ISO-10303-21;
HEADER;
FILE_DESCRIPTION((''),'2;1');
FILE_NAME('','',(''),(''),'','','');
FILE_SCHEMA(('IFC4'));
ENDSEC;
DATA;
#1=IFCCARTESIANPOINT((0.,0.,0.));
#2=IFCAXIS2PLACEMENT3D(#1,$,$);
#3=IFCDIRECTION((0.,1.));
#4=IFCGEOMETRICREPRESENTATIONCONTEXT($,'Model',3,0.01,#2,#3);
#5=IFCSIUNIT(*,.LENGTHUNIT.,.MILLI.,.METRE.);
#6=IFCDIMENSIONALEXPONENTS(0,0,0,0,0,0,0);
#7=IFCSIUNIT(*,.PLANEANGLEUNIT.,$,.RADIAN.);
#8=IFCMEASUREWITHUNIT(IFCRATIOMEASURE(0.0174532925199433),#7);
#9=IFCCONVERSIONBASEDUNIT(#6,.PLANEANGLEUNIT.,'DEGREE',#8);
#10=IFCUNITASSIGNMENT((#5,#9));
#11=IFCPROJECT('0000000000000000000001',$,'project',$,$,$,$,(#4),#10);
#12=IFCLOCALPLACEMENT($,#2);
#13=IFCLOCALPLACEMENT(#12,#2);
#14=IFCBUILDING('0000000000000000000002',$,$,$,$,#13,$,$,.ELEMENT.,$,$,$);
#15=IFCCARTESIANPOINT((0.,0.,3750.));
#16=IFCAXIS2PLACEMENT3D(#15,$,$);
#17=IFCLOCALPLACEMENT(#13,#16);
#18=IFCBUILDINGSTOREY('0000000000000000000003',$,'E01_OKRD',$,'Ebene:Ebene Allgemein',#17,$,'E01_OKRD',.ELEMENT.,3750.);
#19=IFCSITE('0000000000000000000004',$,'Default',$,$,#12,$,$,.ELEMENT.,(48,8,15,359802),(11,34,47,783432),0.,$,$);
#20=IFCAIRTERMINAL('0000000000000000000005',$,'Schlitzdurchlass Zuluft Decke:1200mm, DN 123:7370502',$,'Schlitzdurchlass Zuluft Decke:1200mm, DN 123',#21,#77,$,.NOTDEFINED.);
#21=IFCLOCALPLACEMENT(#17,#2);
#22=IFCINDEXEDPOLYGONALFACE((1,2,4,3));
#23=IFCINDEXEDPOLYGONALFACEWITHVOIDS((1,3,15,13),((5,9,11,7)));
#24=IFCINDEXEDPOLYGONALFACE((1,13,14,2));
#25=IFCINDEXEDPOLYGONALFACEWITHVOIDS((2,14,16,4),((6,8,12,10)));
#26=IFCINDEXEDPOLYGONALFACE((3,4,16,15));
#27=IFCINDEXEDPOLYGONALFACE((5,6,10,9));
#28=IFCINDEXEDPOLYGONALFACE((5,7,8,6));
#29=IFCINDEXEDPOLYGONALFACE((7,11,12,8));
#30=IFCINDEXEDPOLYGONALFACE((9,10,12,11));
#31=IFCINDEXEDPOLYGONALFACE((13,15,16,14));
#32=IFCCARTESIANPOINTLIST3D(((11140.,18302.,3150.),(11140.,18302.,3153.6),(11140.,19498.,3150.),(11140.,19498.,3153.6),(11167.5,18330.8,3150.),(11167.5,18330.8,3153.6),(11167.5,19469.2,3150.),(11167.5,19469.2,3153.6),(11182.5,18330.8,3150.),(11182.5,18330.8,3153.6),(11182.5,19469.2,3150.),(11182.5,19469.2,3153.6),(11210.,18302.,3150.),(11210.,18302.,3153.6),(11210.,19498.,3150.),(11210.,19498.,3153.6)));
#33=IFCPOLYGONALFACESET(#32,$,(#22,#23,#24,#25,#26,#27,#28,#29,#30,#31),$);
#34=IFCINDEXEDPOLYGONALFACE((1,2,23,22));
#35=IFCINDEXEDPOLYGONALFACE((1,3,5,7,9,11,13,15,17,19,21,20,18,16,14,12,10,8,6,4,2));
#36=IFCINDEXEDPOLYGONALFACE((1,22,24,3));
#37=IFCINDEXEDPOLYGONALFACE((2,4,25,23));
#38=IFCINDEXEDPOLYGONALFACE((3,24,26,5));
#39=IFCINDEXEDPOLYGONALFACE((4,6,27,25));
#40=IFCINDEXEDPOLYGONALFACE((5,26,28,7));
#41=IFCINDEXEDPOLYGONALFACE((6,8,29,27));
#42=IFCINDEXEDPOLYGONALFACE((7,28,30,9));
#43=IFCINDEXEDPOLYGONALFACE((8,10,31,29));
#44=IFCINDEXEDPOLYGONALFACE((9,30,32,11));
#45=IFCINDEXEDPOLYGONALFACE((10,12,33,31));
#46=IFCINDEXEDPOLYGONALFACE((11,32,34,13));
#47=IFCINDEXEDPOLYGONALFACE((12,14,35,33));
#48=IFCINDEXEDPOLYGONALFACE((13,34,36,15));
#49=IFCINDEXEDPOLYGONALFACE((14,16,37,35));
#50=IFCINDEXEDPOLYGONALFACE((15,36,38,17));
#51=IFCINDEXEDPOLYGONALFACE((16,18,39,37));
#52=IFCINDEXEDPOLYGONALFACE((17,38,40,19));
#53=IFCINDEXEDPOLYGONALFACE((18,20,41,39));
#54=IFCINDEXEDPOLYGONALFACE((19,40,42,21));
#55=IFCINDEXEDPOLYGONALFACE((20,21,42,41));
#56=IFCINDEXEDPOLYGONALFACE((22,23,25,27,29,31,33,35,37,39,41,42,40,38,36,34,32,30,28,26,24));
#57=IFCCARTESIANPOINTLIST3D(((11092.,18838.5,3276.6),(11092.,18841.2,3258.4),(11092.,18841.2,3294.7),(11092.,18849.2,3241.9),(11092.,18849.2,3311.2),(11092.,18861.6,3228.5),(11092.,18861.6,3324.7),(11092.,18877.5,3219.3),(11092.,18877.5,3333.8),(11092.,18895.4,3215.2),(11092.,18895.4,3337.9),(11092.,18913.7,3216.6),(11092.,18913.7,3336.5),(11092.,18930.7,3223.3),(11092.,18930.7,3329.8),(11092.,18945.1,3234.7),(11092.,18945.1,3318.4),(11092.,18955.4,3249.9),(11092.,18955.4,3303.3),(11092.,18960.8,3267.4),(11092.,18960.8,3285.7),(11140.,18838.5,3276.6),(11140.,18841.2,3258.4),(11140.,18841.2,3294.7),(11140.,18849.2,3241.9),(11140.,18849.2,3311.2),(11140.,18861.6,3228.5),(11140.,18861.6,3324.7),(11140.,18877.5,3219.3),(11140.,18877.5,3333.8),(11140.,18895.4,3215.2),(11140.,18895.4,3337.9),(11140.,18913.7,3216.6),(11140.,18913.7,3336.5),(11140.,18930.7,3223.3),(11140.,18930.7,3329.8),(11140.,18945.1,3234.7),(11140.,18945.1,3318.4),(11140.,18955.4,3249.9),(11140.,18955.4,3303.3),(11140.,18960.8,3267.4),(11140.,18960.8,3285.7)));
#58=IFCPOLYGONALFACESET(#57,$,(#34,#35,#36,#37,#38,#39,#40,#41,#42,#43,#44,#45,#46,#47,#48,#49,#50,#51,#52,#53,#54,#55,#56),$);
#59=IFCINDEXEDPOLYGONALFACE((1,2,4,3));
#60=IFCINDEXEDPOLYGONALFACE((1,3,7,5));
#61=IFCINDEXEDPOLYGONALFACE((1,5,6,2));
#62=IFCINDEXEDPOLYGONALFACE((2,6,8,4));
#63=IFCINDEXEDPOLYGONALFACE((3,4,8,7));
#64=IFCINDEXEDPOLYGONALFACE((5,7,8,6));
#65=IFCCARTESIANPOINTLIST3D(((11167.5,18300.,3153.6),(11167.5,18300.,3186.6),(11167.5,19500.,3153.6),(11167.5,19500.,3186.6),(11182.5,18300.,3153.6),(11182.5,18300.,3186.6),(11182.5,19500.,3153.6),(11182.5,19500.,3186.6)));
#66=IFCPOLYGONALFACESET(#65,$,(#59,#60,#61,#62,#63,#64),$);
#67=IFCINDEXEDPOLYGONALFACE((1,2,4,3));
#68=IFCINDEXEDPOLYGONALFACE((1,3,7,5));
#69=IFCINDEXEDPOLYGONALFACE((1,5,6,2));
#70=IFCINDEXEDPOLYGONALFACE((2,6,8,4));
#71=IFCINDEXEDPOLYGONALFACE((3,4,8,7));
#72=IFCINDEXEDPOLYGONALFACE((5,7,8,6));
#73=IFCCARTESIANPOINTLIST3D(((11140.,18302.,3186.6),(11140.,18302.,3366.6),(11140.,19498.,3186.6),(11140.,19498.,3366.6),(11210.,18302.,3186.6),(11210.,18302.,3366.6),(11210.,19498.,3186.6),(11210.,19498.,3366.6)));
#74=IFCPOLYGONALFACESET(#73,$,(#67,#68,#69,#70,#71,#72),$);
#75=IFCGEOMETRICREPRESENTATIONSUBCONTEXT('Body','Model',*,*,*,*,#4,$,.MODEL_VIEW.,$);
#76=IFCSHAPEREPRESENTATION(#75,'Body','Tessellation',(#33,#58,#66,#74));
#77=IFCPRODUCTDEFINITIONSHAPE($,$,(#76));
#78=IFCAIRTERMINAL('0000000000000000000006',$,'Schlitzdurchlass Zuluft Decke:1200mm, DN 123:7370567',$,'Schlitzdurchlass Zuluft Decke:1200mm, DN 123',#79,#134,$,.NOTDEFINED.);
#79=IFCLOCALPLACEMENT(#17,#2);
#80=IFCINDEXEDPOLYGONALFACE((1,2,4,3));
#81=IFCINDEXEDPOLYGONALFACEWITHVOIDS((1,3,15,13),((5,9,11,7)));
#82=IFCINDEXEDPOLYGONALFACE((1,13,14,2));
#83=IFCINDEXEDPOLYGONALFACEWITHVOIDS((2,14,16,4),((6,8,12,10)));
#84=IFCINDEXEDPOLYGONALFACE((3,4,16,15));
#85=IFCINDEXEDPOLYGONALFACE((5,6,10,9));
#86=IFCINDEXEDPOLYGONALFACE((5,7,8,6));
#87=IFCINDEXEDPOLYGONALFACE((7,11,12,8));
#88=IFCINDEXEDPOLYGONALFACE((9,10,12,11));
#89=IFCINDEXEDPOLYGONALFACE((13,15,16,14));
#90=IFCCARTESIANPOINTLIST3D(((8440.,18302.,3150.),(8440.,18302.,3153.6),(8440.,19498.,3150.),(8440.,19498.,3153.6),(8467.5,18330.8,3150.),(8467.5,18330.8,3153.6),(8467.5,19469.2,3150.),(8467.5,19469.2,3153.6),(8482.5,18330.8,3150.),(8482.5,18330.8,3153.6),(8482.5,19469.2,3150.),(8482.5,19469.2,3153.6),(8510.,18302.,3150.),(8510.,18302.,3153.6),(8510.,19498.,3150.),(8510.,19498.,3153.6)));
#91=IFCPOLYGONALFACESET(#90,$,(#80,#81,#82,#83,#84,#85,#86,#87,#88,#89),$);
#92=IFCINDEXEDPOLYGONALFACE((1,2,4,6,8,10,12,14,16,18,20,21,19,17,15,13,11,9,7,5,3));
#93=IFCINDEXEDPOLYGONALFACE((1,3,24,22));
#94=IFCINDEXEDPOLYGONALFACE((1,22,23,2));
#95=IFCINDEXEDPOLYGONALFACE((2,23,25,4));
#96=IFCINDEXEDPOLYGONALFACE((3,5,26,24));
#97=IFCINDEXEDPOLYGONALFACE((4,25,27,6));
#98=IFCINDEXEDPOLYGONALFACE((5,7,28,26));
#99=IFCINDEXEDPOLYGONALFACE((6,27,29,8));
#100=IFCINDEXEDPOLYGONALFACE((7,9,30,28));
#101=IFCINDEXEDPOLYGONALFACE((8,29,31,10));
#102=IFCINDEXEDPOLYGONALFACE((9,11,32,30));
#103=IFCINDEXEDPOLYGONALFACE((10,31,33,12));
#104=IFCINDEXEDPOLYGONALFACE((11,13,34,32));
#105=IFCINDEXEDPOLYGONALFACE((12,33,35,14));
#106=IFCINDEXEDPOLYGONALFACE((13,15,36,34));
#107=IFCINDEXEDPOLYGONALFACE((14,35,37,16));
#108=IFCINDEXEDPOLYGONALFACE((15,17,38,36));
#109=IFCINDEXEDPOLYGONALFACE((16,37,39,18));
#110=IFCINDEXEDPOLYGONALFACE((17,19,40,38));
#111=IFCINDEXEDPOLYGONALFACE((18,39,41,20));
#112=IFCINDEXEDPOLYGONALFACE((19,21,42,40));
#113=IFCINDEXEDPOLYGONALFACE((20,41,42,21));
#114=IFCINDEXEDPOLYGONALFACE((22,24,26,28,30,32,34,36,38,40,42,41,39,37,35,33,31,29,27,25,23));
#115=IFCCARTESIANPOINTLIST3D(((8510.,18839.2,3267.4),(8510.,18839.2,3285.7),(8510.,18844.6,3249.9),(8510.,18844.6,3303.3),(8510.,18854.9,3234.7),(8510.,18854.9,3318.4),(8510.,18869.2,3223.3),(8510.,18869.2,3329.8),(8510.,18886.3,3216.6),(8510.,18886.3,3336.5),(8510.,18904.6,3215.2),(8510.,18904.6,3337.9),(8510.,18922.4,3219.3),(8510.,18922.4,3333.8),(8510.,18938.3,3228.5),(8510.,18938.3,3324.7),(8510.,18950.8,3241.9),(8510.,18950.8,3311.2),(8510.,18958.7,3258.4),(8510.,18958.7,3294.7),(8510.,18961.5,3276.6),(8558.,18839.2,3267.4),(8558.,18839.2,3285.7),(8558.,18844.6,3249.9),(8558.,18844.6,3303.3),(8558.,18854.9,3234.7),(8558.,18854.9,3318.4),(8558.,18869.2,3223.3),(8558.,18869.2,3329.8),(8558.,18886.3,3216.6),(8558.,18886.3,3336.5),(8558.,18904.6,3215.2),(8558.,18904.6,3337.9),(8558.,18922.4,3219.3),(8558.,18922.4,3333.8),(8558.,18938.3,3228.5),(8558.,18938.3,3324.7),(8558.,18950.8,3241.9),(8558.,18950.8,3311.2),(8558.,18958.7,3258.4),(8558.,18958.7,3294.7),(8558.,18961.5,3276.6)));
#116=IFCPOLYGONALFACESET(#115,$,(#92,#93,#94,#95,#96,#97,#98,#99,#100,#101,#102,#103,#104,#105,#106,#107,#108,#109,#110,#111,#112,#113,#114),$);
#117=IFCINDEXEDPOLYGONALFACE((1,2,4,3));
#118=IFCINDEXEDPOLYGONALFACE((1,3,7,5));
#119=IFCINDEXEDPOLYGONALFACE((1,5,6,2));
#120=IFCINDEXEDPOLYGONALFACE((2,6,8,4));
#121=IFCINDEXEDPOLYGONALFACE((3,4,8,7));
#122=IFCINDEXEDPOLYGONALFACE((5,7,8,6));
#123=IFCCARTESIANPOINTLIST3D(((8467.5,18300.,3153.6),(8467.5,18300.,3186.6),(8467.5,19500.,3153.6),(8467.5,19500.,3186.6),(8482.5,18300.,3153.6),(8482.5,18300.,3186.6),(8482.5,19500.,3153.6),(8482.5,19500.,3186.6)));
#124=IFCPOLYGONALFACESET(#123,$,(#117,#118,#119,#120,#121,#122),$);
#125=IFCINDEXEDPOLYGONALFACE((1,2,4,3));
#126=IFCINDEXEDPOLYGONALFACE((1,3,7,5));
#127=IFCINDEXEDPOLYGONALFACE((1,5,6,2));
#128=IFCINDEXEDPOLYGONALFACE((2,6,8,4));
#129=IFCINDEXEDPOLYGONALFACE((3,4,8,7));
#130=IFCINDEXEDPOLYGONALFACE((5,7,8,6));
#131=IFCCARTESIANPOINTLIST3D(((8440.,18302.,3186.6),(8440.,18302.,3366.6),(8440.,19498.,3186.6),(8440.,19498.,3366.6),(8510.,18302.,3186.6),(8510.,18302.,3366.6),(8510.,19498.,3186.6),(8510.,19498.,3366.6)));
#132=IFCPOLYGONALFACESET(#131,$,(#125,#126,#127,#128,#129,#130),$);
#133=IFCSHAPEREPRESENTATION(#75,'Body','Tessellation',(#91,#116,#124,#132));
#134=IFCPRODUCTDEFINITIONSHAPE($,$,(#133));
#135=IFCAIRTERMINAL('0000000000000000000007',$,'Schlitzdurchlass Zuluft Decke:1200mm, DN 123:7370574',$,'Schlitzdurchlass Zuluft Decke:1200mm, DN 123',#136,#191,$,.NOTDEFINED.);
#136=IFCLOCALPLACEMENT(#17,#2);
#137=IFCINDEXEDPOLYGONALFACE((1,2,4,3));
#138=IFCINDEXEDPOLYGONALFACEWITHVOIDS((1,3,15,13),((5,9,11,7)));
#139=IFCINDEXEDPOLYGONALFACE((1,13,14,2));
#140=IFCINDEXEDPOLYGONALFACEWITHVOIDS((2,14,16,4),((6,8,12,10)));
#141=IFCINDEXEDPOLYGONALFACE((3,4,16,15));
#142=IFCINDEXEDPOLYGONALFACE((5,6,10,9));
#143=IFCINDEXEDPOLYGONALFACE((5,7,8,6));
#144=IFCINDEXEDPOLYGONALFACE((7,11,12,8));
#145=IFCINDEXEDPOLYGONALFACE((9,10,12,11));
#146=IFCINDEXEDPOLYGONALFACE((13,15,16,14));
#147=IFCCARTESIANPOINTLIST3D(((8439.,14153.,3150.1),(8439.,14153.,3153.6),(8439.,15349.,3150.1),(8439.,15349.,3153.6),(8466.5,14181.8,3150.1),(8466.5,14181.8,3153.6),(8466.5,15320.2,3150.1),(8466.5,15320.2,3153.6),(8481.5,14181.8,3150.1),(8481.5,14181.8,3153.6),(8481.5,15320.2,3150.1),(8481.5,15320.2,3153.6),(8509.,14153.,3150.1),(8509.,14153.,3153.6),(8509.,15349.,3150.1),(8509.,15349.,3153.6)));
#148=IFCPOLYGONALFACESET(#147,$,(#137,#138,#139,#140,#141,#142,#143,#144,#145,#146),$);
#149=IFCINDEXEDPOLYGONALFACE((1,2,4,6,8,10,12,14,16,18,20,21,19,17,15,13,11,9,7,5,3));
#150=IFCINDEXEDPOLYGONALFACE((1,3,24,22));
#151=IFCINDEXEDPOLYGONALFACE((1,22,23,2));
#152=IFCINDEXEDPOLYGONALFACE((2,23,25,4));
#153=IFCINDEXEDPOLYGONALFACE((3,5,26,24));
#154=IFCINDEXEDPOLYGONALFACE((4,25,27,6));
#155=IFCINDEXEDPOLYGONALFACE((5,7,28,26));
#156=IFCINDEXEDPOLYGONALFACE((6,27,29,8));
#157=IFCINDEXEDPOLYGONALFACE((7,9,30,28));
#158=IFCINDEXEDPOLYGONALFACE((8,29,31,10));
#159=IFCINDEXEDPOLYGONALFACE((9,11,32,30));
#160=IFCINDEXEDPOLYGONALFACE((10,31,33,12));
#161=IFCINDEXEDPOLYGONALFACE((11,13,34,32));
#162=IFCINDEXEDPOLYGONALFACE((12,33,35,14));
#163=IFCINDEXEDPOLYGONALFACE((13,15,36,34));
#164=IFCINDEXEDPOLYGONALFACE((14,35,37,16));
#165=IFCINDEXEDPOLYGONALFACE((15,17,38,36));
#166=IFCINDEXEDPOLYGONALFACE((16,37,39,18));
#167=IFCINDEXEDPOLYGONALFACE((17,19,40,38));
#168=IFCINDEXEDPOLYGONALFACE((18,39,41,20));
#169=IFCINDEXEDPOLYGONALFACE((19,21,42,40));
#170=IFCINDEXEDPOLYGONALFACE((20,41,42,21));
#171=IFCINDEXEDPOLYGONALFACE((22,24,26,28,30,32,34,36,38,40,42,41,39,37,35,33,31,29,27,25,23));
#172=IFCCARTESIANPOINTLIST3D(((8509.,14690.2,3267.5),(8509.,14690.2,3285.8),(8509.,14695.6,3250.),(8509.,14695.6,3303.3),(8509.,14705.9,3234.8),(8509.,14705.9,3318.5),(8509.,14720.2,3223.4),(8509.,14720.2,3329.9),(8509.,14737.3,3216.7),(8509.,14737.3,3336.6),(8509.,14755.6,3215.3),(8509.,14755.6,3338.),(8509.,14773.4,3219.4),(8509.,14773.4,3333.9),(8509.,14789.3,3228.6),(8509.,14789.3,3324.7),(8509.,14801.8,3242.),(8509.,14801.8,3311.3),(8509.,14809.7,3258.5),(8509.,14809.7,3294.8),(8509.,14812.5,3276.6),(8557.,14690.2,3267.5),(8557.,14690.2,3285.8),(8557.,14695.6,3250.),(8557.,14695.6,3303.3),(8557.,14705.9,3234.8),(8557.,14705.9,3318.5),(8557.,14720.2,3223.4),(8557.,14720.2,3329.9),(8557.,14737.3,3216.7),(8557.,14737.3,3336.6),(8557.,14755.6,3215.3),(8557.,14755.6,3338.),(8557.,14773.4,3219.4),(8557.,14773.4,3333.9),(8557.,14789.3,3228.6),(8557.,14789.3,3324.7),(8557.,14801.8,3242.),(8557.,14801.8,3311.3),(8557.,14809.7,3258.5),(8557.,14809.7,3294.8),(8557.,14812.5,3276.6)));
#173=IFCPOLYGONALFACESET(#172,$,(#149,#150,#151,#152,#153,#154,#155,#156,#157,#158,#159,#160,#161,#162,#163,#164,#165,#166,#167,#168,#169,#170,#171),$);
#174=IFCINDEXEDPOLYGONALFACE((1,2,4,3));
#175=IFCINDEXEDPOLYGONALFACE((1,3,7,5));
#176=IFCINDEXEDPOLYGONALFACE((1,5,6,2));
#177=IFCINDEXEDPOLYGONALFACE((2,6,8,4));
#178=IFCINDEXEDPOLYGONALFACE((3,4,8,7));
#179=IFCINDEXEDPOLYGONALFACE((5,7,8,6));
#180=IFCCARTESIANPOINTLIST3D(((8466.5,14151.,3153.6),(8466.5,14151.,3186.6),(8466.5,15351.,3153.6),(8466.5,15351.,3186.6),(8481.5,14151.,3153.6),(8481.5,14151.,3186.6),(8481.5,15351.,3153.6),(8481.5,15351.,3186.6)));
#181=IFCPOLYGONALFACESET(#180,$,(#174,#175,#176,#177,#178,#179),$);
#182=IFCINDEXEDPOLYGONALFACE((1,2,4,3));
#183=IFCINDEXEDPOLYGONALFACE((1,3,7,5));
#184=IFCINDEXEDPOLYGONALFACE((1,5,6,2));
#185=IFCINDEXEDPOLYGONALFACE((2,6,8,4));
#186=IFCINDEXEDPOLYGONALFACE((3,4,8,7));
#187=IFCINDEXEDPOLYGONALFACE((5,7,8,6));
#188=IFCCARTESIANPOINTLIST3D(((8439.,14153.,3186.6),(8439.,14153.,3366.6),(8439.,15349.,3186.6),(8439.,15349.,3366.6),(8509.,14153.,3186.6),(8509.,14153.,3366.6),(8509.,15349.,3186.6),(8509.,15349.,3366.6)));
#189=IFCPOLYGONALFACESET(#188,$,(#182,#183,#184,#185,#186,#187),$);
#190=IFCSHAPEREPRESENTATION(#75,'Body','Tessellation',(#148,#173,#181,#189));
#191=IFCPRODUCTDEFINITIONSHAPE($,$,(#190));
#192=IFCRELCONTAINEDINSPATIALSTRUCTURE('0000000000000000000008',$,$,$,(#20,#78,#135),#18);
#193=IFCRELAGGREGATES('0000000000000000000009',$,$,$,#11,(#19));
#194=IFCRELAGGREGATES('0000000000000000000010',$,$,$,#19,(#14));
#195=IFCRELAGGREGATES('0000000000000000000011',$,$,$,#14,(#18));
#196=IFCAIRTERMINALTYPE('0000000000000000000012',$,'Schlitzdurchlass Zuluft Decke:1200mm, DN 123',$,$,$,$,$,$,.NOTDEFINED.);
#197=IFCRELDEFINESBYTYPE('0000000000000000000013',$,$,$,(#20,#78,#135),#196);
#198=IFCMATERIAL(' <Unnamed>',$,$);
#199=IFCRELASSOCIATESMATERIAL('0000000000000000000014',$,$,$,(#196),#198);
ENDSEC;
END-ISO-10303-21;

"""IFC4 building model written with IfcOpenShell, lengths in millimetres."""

from ifc_helpers import new_model, entity, si_unit, converted_unit, direction, frame, frame_2d, origin, origin_2d_with_axis, place, context, subcontext, project, spatial, polyline, rectangle, circle, outline, extrude, source, transform, mapped, material, type_object, type_shapes, element, save


model = new_model("IFC4")

# Units and contexts
model_context = context("Model", 3, precision=0.01, world=origin(), true_north=direction((0.0, 1.0)))
body_context = subcontext(model_context, "Body", "Model", "MODEL_VIEW")
ifc_project = project(units=[si_unit("LENGTHUNIT", "METRE", prefix="MILLI"), converted_unit("PLANEANGLEUNIT", "DEGREE", entity("IfcRatioMeasure", 0.0174532925199433), si_unit("PLANEANGLEUNIT", "RADIAN"), dimensions=[0, 0, 0, 0, 0, 0, 0])], contexts=[model_context])

# Site, building, storey
site_placement = place(None, origin())
site = spatial("IfcSite", under=ifc_project, at=site_placement, Name="Default", CompositionType="ELEMENT", RefLatitude=(48, 8, 15, 359802), RefLongitude=(11, 34, 47, 783432), RefElevation=0.0)
building_placement = place(site_placement, origin())
building = spatial("IfcBuilding", under=site, at=building_placement, CompositionType="ELEMENT")
storey_placement = place(building_placement, frame((0.0, 0.0, 3750.0)))
storey = spatial("IfcBuildingStorey", under=building, at=storey_placement, Name="E01_OKRD", ObjectType="Ebene:Ebene Allgemein", LongName="E01_OKRD", CompositionType="ELEMENT", Elevation=3750.0)

# Shared definitions
ifc_material_1 = material(Name=" <Unnamed>")

# Air terminals
air_terminal_type_1 = type_object("IfcAirTerminalType", Name="Schlitzdurchlass Zuluft Decke:1200mm, DN 123", PredefinedType="NOTDEFINED", material=ifc_material_1)
shared_shape_1 = source(origin(), body_context, "Body", "SweptSolid", [
    extrude(outline(polyline([(-598.0, -35.0), (598.0, -35.0), (598.0, 35.0), (-598.0, 35.0), (-598.0, -35.0)]), holes=[polyline([(-569.2, -7.5), (-569.2, 7.5), (569.2, 7.5), (569.2, -7.5), (-569.2, -7.5)])]), frame((600.0, 35.0, 0.0), z_axis=(0.0, 0.0, 1.0), x_axis=(-1.0, 0.0, 0.0)), (0.0, 0.0, 1.0), 3.6),
    extrude(circle(Radius=61.5, at=frame_2d((0.0, 0.0), x_axis=(1.0, 0.0))), frame((600.0, 70.0, 126.6), z_axis=(0.0, 1.0, 0.0), x_axis=(-1.0, 0.0, 0.0)), (0.0, 0.0, 1.0), 48.0),
    extrude(rectangle(XDim=1200.0, YDim=15.0, at=origin_2d_with_axis()), frame((600.0, 35.0, 3.6), z_axis=(0.0, 0.0, 1.0), x_axis=(-1.0, 0.0, 0.0)), (0.0, 0.0, 1.0), 33.0),
    extrude(rectangle(XDim=1196.0, YDim=70.0, at=origin_2d_with_axis()), frame((600.0, 35.0, 36.6), z_axis=(0.0, 0.0, 1.0), x_axis=(-1.0, 0.0, 0.0)), (0.0, 0.0, 1.0), 180.0),
])
type_shapes(air_terminal_type_1, [shared_shape_1])
for number, where, z_axis, x_axis, name in (
    (1, (11210.0, 18300.0, 3150.0), (0.0, 0.0, 1.0), (0.0, 1.0, 0.0), "Schlitzdurchlass Zuluft Decke:1200mm, DN 123:7370502"),
    (2, (8440.0, 19500.0, 3150.0), (0.0, 0.0, 1.0), (0.0, -1.0, 0.0), "Schlitzdurchlass Zuluft Decke:1200mm, DN 123:7370567"),
    (3, (8439.0, 15351.0, 3150.1), (0.0, 0.0, 1.0), (0.0, -1.0, 0.0), "Schlitzdurchlass Zuluft Decke:1200mm, DN 123:7370574"),
):
    element("IfcAirTerminal", number, at=place(storey_placement, frame(where, z_axis=z_axis, x_axis=x_axis)), inside=storey, type_object=air_terminal_type_1, Name=name, ObjectType="Schlitzdurchlass Zuluft Decke:1200mm, DN 123", PredefinedType="NOTDEFINED", context=body_context, shape_type="MappedRepresentation", body=[
        mapped(shared_shape_1, transform((0.0, 0.0, 0.0), scale=1.0)),
    ])

save(model, "model.ifc")
